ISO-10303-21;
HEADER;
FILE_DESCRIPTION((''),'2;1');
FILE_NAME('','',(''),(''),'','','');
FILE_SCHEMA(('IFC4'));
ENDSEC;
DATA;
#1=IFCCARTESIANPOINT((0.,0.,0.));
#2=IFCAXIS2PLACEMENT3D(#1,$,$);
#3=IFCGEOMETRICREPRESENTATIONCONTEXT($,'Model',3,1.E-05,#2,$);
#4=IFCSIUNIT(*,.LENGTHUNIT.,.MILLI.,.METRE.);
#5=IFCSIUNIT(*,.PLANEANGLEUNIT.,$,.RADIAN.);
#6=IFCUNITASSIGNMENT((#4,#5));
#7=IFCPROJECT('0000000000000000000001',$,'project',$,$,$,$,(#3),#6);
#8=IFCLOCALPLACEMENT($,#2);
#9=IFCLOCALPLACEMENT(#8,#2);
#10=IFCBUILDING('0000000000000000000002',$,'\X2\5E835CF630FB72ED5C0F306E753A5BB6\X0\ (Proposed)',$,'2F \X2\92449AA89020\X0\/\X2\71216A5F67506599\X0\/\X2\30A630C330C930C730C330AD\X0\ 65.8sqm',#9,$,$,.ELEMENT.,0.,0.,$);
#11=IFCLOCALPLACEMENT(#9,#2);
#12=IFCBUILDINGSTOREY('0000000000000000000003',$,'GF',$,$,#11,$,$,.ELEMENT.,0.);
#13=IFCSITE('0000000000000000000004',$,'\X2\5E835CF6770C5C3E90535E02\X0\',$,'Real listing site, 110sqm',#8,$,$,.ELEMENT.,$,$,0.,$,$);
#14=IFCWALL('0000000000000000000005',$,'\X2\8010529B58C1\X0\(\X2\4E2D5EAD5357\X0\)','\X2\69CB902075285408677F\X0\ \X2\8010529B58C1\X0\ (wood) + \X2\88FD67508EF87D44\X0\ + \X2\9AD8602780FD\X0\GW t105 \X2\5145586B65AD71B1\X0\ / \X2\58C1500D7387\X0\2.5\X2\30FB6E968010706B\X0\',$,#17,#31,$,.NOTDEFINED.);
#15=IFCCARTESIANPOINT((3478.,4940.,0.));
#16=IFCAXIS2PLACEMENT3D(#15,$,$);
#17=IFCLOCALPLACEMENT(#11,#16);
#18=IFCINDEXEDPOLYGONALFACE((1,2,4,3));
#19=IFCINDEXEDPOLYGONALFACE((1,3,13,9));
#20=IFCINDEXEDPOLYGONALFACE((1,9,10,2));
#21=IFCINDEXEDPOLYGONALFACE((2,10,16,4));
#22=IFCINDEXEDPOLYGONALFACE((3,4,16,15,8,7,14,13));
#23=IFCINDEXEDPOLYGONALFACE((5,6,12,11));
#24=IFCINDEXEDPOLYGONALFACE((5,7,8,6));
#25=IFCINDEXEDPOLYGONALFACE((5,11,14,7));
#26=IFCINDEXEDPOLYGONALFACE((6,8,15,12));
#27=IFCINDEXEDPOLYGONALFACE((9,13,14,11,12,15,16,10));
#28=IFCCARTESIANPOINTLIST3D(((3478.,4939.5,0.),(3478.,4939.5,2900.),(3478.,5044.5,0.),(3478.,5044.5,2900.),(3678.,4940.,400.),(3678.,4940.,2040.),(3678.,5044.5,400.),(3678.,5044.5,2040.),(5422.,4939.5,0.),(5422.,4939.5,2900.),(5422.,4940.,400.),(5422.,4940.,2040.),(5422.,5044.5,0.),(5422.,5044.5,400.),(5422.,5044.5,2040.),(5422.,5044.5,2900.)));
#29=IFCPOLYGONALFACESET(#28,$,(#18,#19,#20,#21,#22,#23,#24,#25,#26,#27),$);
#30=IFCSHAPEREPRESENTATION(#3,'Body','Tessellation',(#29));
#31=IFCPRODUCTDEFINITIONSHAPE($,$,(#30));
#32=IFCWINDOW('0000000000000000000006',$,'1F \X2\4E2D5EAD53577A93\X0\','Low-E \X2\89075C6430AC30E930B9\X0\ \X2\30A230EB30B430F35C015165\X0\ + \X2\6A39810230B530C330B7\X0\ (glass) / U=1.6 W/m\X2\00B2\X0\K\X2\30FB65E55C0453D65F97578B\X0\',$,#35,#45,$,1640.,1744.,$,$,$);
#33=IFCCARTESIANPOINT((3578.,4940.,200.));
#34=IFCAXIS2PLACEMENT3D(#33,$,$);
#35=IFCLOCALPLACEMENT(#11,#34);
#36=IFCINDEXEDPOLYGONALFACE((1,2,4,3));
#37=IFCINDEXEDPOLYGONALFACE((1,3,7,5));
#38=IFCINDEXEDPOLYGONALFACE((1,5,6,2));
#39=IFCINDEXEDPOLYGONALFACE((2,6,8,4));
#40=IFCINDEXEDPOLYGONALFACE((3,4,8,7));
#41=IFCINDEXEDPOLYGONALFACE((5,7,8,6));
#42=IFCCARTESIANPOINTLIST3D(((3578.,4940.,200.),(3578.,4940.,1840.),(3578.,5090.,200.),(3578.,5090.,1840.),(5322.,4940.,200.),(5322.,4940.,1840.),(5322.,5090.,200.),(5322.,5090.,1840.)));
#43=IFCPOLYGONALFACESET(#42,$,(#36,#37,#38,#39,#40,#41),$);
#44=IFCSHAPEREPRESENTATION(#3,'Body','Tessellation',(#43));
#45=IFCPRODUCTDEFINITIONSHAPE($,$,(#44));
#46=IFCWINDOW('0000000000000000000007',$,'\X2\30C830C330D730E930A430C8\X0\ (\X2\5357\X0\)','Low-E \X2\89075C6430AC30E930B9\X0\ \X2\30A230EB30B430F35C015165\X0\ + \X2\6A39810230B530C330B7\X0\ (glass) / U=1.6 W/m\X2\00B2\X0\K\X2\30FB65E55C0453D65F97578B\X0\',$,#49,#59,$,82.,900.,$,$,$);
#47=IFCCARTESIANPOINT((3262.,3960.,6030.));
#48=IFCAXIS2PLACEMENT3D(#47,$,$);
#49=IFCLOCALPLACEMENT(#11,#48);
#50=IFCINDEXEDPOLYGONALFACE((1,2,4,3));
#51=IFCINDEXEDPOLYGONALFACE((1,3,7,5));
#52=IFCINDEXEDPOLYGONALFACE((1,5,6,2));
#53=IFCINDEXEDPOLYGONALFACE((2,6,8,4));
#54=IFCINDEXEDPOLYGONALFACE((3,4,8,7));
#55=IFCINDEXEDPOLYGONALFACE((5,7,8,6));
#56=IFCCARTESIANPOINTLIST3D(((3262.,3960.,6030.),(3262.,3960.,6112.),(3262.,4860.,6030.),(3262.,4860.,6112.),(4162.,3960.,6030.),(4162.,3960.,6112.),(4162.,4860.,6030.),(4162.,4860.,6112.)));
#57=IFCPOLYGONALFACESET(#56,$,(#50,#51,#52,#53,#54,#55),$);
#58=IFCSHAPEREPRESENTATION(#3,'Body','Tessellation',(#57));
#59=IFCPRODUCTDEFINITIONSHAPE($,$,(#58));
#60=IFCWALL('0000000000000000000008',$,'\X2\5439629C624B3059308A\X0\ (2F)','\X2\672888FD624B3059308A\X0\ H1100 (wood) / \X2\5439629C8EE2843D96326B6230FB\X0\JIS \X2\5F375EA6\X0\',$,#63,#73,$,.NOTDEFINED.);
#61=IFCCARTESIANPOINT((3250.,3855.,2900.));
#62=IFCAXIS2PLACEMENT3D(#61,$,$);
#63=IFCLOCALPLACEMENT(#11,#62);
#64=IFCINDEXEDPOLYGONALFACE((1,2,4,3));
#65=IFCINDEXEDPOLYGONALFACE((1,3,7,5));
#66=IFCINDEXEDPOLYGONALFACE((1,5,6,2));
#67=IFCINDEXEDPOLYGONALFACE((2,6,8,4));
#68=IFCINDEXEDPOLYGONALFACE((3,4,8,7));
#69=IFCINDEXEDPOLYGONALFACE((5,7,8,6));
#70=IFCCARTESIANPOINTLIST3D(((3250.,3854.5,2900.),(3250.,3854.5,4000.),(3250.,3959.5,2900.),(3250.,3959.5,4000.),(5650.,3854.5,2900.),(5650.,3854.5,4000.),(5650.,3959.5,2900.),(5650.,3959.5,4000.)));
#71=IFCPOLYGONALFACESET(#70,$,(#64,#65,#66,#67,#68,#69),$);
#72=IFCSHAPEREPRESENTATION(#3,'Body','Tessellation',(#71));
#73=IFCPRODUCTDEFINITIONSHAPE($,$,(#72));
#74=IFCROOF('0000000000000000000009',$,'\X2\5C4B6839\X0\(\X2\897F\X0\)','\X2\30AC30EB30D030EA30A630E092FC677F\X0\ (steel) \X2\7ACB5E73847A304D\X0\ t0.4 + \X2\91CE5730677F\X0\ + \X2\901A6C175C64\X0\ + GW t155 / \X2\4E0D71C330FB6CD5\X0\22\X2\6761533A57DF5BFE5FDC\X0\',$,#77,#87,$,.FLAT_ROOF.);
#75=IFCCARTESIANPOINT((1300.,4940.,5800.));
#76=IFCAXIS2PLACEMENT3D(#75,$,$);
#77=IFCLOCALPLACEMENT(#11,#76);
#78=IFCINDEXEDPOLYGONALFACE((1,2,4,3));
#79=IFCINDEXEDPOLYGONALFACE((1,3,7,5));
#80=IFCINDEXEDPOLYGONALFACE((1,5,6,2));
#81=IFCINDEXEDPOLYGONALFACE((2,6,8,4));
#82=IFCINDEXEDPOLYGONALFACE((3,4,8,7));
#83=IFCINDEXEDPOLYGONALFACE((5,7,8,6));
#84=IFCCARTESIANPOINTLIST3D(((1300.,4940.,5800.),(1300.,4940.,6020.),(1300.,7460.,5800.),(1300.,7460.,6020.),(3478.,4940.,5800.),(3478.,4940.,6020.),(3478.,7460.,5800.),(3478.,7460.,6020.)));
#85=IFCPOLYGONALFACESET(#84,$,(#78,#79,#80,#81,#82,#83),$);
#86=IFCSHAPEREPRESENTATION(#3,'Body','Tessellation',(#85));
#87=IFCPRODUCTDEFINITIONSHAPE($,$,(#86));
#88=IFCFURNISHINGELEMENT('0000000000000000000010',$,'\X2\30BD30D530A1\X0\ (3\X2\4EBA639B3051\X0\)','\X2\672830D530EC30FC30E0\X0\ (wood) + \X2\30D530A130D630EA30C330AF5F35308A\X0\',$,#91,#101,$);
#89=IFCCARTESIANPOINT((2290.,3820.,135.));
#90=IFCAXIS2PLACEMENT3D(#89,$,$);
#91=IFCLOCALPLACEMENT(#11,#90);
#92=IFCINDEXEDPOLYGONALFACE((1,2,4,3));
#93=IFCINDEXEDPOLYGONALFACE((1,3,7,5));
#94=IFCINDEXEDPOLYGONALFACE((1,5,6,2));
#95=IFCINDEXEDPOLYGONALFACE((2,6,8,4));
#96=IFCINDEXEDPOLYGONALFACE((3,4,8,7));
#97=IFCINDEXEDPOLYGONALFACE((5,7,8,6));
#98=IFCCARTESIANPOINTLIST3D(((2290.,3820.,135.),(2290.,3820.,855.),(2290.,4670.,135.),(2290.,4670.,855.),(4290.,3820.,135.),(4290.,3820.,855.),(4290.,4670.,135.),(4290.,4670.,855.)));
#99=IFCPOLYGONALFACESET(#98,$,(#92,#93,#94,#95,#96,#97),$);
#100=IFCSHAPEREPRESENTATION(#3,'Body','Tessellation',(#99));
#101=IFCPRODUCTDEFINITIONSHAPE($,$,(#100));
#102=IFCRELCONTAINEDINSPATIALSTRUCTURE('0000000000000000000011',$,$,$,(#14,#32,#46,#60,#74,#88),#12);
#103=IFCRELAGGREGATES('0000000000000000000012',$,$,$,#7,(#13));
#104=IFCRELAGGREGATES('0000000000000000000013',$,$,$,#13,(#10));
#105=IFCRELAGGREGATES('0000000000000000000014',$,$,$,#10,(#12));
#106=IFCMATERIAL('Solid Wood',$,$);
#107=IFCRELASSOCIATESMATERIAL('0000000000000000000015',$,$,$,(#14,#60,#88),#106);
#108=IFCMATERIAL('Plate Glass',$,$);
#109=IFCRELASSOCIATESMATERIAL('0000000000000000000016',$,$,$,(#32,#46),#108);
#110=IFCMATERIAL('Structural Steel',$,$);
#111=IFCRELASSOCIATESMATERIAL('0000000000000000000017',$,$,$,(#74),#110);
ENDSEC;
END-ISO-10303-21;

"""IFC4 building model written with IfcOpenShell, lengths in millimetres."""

from ifc_helpers import new_model, si_unit, frame, frame_2d, origin, place, context, project, spatial, rectangle, extrude, material, element, fill, save


model = new_model("IFC4")

# Units and contexts
model_context = context("Model", 3, precision=1e-05, world=origin())
ifc_project = project(units=[si_unit("LENGTHUNIT", "METRE", prefix="MILLI"), si_unit("PLANEANGLEUNIT", "RADIAN")], contexts=[model_context])

# Site, building, storey
site_placement = place(None, origin())
site = spatial("IfcSite", under=ifc_project, at=site_placement, Name="広島県尾道市", ObjectType="Real listing site, 110sqm", CompositionType="ELEMENT", RefElevation=0.0)
building_placement = place(site_placement, origin())
building = spatial("IfcBuilding", under=site, at=building_placement, Name="広島・狭小の町家 (Proposed)", ObjectType="2F 鉄骨造/無機材料/ウッドデッキ 65.8sqm", CompositionType="ELEMENT", ElevationOfRefHeight=0.0, ElevationOfTerrain=0.0)
storey_placement = place(building_placement, origin())
storey = spatial("IfcBuildingStorey", under=building, at=storey_placement, Name="GF", CompositionType="ELEMENT", Elevation=0.0)

# Shared definitions
ifc_material_1 = material(Name="Solid Wood")

# Wall, opening, window
wall_1_placement = place(storey_placement, frame((3478.0, 4940.0, 0.0)))
wall_1 = element("IfcWall", 1, at=wall_1_placement, inside=storey, material=ifc_material_1, Name="耐力壁(中庭南)", Description="構造用合板 耐力壁 (wood) + 製材軸組 + 高性能GW t105 充填断熱 / 壁倍率2.5・準耐火", PredefinedType="NOTDEFINED", context=model_context, shape_type="SweptSolid", body=[
    extrude(rectangle(XDim=1944.0, YDim=105.0, at=frame_2d((972.0, 52.0))), frame((3478.0, 4940.0, 0.0)), (0.0, 0.0, 1.0), 2900.0),
])
opening_placement = place(storey_placement, frame((3578.0, 4940.0, 200.0)))
opening = element("IfcOpeningElement", 2, at=opening_placement, cuts=wall_1, PredefinedType="NOTDEFINED", context=model_context, shape_type="SweptSolid", body=[
    extrude(rectangle(XDim=1744.0, YDim=150.0, at=frame_2d((872.0, 75.0))), frame((3578.0, 4940.0, 200.0)), (0.0, 0.0, 1.0), 1640.0),
])
ifc_material_2 = material(Name="Plate Glass")
window_1_placement = place(storey_placement, frame((3578.0, 4940.0, 200.0)))
window_1 = element("IfcWindow", 3, at=window_1_placement, inside=storey, material=ifc_material_2, Name="1F 中庭南窓", Description="Low-E 複層ガラス アルゴン封入 + 樹脂サッシ (glass) / U=1.6 W/m²K・日射取得型", OverallHeight=1640.0, OverallWidth=1744.0, context=model_context, shape_type="SweptSolid", body=[
    extrude(rectangle(XDim=1744.0, YDim=150.0, at=frame_2d((872.0, 75.0))), frame((3578.0, 4940.0, 200.0)), (0.0, 0.0, 1.0), 1640.0),
])
fill(opening, window_1)

# Window
window_2_placement = place(storey_placement, frame((3262.0, 3960.0, 6030.0)))
element("IfcWindow", 4, at=window_2_placement, inside=storey, material=ifc_material_2, Name="トップライト (南)", Description="Low-E 複層ガラス アルゴン封入 + 樹脂サッシ (glass) / U=1.6 W/m²K・日射取得型", OverallHeight=82.0, OverallWidth=900.0, context=model_context, shape_type="SweptSolid", body=[
    extrude(rectangle(XDim=900.0, YDim=900.0, at=frame_2d((450.0, 450.0))), frame((3262.0, 3960.0, 6030.0)), (0.0, 0.0, 1.0), 82.0),
])

# Wall
wall_2_placement = place(storey_placement, frame((3250.0, 3855.0, 2900.0)))
element("IfcWall", 5, at=wall_2_placement, inside=storey, material=ifc_material_1, Name="吹抜手すり (2F)", Description="木製手すり H1100 (wood) / 吹抜転落防止・JIS 強度", PredefinedType="NOTDEFINED", context=model_context, shape_type="SweptSolid", body=[
    extrude(rectangle(XDim=2400.0, YDim=105.0, at=frame_2d((1200.0, 52.0))), frame((3250.0, 3855.0, 2900.0)), (0.0, 0.0, 1.0), 1100.0),
])

# Roof
ifc_material_3 = material(Name="Structural Steel")
for number, where, name in (
    (6, (1300.0, 4940.0, 5800.0), "屋根(西)"),
):
    element("IfcRoof", number, at=place(storey_placement, frame(where)), inside=storey, material=ifc_material_3, Name=name, Description="ガルバリウム鋼板 (steel) 立平葺き t0.4 + 野地板 + 通気層 + GW t155 / 不燃・法22条区域対応", PredefinedType="FLAT_ROOF", context=model_context, shape_type="SweptSolid", body=[
        extrude(rectangle(XDim=2178.0, YDim=2520.0, at=frame_2d((1089.0, 1260.0))), frame((1300.0, 4940.0, 5800.0)), (0.0, 0.0, 1.0), 220.0),
    ])

# Furnishing element
furnishing_placement = place(storey_placement, frame((2290.0, 3820.0, 135.0)))
element("IfcFurnishingElement", 7, at=furnishing_placement, inside=storey, material=ifc_material_1, Name="ソファ (3人掛け)", Description="木フレーム (wood) + ファブリック張り", context=model_context, shape_type="SweptSolid", body=[
    extrude(rectangle(XDim=2000.0, YDim=850.0, at=frame_2d((1000.0, 425.0))), frame((2290.0, 3820.0, 135.0)), (0.0, 0.0, 1.0), 720.0),
])

save(model, "model.ifc")
